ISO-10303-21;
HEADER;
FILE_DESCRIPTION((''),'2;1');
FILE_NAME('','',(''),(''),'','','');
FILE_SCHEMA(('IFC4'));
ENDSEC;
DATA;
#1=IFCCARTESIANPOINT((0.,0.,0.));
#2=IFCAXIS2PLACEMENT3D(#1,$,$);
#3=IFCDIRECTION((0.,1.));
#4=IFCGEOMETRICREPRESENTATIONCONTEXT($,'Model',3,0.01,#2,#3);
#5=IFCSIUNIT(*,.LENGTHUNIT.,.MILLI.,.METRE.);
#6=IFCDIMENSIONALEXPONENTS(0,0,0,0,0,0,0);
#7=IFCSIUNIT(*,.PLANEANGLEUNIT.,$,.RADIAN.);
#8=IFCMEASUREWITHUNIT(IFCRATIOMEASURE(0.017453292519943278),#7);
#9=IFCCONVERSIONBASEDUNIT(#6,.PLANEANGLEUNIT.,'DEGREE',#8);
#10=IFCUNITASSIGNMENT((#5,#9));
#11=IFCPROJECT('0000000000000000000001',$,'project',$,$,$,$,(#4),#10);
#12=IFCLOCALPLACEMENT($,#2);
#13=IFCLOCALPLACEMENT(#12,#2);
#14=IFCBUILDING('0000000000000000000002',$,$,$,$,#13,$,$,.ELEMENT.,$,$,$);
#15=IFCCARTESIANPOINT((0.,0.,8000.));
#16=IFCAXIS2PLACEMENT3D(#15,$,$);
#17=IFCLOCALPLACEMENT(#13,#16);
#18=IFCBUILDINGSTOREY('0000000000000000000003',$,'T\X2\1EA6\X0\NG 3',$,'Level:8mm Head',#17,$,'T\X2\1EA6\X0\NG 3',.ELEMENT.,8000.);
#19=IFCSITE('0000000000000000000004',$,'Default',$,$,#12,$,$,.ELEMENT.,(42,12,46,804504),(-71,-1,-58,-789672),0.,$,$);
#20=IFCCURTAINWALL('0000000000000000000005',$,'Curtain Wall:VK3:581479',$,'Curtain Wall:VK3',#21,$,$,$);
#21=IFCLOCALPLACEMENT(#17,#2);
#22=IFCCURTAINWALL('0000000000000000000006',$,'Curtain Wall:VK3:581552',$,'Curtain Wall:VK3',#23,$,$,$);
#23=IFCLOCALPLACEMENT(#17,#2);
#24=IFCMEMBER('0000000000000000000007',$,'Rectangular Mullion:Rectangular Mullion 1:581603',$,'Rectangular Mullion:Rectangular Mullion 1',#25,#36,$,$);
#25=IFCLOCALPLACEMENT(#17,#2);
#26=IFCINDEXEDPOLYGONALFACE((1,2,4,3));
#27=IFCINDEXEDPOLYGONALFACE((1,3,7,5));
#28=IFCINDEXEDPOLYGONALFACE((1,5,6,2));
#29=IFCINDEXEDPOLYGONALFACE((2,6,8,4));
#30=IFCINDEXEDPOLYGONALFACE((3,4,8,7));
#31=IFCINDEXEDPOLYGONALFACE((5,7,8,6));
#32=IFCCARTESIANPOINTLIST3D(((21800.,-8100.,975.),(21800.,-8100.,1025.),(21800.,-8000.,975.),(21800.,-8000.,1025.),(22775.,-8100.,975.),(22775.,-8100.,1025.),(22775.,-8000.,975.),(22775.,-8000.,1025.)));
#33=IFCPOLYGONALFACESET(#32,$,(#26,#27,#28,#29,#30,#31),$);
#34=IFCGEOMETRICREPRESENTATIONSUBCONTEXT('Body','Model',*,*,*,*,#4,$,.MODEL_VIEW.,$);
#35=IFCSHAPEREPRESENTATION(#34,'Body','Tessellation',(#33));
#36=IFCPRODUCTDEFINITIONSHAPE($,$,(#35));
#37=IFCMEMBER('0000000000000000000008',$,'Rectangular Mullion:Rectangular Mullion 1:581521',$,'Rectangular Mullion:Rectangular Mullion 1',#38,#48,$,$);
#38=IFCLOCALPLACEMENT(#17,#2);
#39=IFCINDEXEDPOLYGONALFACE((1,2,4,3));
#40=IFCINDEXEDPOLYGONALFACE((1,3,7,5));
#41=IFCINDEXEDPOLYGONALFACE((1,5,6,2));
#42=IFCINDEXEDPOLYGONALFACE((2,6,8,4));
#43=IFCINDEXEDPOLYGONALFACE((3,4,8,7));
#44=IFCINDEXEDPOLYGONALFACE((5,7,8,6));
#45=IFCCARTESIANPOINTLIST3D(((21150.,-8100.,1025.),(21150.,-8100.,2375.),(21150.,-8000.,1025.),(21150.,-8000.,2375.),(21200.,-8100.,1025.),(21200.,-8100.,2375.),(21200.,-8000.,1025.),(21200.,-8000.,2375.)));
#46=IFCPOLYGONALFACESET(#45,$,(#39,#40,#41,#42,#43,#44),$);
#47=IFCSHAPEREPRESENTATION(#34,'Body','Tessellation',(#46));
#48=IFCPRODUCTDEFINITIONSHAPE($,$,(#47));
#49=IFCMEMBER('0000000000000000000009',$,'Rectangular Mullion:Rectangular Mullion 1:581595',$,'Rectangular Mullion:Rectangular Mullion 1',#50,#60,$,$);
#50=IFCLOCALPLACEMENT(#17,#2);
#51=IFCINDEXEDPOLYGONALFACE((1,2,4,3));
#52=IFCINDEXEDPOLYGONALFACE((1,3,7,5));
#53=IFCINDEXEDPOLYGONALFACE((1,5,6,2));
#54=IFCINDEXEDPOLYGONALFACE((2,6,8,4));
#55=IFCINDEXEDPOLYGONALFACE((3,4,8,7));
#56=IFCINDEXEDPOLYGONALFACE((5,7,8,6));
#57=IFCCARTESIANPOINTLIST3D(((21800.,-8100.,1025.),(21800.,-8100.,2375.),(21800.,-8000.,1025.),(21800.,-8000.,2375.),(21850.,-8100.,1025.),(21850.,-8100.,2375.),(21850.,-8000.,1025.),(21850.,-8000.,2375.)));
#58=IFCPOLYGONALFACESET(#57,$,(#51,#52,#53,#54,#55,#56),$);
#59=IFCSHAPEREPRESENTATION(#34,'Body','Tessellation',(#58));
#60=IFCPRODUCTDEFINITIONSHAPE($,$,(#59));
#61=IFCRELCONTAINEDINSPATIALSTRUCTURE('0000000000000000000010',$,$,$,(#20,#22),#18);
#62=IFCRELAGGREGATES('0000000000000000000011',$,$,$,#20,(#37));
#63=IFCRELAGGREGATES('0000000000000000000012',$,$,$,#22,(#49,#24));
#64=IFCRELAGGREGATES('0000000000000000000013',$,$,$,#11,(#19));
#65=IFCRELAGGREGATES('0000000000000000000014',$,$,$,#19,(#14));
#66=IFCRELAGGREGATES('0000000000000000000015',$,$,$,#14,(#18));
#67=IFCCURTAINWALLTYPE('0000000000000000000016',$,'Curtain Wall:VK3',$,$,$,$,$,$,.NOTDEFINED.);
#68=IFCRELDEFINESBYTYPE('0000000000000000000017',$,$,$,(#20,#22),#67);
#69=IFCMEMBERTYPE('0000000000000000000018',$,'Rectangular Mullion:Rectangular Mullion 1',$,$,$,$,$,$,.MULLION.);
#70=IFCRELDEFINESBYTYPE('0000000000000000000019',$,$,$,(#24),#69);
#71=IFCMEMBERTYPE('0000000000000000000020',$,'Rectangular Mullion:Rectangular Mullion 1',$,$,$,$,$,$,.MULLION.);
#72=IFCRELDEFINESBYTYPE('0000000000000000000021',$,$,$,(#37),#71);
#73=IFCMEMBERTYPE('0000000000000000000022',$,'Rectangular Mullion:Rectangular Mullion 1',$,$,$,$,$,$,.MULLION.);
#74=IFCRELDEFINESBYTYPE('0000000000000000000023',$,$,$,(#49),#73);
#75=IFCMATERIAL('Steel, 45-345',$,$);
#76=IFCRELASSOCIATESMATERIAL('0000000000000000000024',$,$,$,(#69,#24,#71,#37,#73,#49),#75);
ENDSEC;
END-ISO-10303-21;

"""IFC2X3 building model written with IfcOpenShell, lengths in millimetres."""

from ifc_helpers import new_model, entity, si_unit, converted_unit, direction, frame, origin, origin_2d_with_axis, place, context, subcontext, project, spatial, rectangle, extrude, source, transform, mapped, material, type_object, type_shapes, element, aggregate, save


model = new_model("IFC2X3")

# Units and contexts
model_context = context("Model", 3, precision=0.01, world=origin(), true_north=direction((0.0, 1.0)))
body_context = subcontext(model_context, "Body", "Model", "MODEL_VIEW")
ifc_project = project(units=[si_unit("LENGTHUNIT", "METRE", prefix="MILLI"), converted_unit("PLANEANGLEUNIT", "DEGREE", entity("IfcRatioMeasure", 0.017453292519943278), si_unit("PLANEANGLEUNIT", "RADIAN"), dimensions=[0, 0, 0, 0, 0, 0, 0])], contexts=[model_context])

# Site, building, storey
site_placement = place(None, origin())
site = spatial("IfcSite", under=ifc_project, at=site_placement, Name="Default", CompositionType="ELEMENT", RefLatitude=(42, 12, 46, 804504), RefLongitude=(-71, -1, -58, -789672), RefElevation=0.0)
building_placement = place(site_placement, origin())
building = spatial("IfcBuilding", under=site, at=building_placement, CompositionType="ELEMENT")
storey_placement = place(building_placement, frame((0.0, 0.0, 8000.0)))
storey = spatial("IfcBuildingStorey", under=building, at=storey_placement, Name="TẦNG 3", ObjectType="Level:8mm Head", LongName="TẦNG 3", CompositionType="ELEMENT", Elevation=8000.0)

# Curtain wall
curtain_wall_type = type_object("IfcCurtainWallType", Name="Curtain Wall:VK3", PredefinedType="NOTDEFINED")
curtain_wall_1_placement = place(storey_placement, frame((0.0, 0.0, -8000.0)))
curtain_wall_1 = element("IfcCurtainWall", 1, at=curtain_wall_1_placement, inside=storey, type_object=curtain_wall_type, Name="Curtain Wall:VK3:581479", ObjectType="Curtain Wall:VK3")
ifc_material_1 = material(Name="Steel, 45-345")

# Curtain wall
curtain_wall_2_placement = place(storey_placement, frame((0.0, 0.0, -8000.0)))
curtain_wall_2 = element("IfcCurtainWall", 2, at=curtain_wall_2_placement, inside=storey, type_object=curtain_wall_type, Name="Curtain Wall:VK3:581552", ObjectType="Curtain Wall:VK3")

# Members
member_type_1 = type_object("IfcMemberType", Name="Rectangular Mullion:Rectangular Mullion 1", PredefinedType="MULLION", material=ifc_material_1)
shared_shape_1 = source(origin(), body_context, "Body", "SweptSolid", [
    extrude(rectangle(XDim=100.0, YDim=50.0, at=origin_2d_with_axis()), frame((0.0, 50.0, -975.0), z_axis=(0.0, 0.0, 1.0), x_axis=(0.0, -1.0, 0.0)), (0.0, 0.0, 1.0), 975.0),
])
type_shapes(member_type_1, [shared_shape_1])
member_1_placement = place(curtain_wall_2_placement, frame((22775.0, -8000.0, 9000.0), z_axis=(1.0, 0.0, 0.0), x_axis=(0.0, 0.0, 1.0)))
member_1 = element("IfcMember", 3, at=member_1_placement, type_object=member_type_1, material=ifc_material_1, Name="Rectangular Mullion:Rectangular Mullion 1:581603", ObjectType="Rectangular Mullion:Rectangular Mullion 1", context=body_context, shape_type="MappedRepresentation", body=[
    mapped(shared_shape_1, transform((0.0, 0.0, 0.0), scale=1.0)),
])
member_type_2 = type_object("IfcMemberType", Name="Rectangular Mullion:Rectangular Mullion 1", PredefinedType="MULLION", material=ifc_material_1)
shared_shape_2 = source(origin(), body_context, "Body", "SweptSolid", [
    extrude(rectangle(XDim=100.0, YDim=50.0, at=origin_2d_with_axis()), frame((-25.0, 50.0, -1350.0), z_axis=(0.0, 0.0, 1.0), x_axis=(0.0, -1.0, 0.0)), (0.0, 0.0, 1.0), 1350.0),
])
type_shapes(member_type_2, [shared_shape_2])
member_2_placement = place(curtain_wall_1_placement, frame((21200.0, -8000.0, 9025.0), z_axis=(0.0, 0.0, -1.0), x_axis=(1.0, 0.0, 0.0)))
member_2 = element("IfcMember", 4, at=member_2_placement, type_object=member_type_2, material=ifc_material_1, Name="Rectangular Mullion:Rectangular Mullion 1:581521", ObjectType="Rectangular Mullion:Rectangular Mullion 1", context=body_context, shape_type="MappedRepresentation", body=[
    mapped(shared_shape_2, transform((0.0, 0.0, 0.0), scale=1.0)),
])
member_type_3 = type_object("IfcMemberType", Name="Rectangular Mullion:Rectangular Mullion 1", PredefinedType="MULLION", material=ifc_material_1)
shared_shape_3 = source(origin(), body_context, "Body", "SweptSolid", [
    extrude(rectangle(XDim=100.0, YDim=50.0, at=origin_2d_with_axis()), frame((-25.0, 50.0, -1350.0), z_axis=(0.0, 0.0, 1.0), x_axis=(0.0, -1.0, 0.0)), (0.0, 0.0, 1.0), 1350.0),
])
type_shapes(member_type_3, [shared_shape_3])
member_3_placement = place(curtain_wall_2_placement, frame((21800.0, -8000.0, 10375.0), z_axis=(0.0, 0.0, 1.0), x_axis=(-1.0, 0.0, 0.0)))
member_3 = element("IfcMember", 5, at=member_3_placement, type_object=member_type_3, material=ifc_material_1, Name="Rectangular Mullion:Rectangular Mullion 1:581595", ObjectType="Rectangular Mullion:Rectangular Mullion 1", context=body_context, shape_type="MappedRepresentation", body=[
    mapped(shared_shape_3, transform((0.0, 0.0, 0.0), scale=1.0)),
])

aggregate(curtain_wall_1, [member_2])
aggregate(curtain_wall_2, [member_3, member_1])

save(model, "model.ifc")
